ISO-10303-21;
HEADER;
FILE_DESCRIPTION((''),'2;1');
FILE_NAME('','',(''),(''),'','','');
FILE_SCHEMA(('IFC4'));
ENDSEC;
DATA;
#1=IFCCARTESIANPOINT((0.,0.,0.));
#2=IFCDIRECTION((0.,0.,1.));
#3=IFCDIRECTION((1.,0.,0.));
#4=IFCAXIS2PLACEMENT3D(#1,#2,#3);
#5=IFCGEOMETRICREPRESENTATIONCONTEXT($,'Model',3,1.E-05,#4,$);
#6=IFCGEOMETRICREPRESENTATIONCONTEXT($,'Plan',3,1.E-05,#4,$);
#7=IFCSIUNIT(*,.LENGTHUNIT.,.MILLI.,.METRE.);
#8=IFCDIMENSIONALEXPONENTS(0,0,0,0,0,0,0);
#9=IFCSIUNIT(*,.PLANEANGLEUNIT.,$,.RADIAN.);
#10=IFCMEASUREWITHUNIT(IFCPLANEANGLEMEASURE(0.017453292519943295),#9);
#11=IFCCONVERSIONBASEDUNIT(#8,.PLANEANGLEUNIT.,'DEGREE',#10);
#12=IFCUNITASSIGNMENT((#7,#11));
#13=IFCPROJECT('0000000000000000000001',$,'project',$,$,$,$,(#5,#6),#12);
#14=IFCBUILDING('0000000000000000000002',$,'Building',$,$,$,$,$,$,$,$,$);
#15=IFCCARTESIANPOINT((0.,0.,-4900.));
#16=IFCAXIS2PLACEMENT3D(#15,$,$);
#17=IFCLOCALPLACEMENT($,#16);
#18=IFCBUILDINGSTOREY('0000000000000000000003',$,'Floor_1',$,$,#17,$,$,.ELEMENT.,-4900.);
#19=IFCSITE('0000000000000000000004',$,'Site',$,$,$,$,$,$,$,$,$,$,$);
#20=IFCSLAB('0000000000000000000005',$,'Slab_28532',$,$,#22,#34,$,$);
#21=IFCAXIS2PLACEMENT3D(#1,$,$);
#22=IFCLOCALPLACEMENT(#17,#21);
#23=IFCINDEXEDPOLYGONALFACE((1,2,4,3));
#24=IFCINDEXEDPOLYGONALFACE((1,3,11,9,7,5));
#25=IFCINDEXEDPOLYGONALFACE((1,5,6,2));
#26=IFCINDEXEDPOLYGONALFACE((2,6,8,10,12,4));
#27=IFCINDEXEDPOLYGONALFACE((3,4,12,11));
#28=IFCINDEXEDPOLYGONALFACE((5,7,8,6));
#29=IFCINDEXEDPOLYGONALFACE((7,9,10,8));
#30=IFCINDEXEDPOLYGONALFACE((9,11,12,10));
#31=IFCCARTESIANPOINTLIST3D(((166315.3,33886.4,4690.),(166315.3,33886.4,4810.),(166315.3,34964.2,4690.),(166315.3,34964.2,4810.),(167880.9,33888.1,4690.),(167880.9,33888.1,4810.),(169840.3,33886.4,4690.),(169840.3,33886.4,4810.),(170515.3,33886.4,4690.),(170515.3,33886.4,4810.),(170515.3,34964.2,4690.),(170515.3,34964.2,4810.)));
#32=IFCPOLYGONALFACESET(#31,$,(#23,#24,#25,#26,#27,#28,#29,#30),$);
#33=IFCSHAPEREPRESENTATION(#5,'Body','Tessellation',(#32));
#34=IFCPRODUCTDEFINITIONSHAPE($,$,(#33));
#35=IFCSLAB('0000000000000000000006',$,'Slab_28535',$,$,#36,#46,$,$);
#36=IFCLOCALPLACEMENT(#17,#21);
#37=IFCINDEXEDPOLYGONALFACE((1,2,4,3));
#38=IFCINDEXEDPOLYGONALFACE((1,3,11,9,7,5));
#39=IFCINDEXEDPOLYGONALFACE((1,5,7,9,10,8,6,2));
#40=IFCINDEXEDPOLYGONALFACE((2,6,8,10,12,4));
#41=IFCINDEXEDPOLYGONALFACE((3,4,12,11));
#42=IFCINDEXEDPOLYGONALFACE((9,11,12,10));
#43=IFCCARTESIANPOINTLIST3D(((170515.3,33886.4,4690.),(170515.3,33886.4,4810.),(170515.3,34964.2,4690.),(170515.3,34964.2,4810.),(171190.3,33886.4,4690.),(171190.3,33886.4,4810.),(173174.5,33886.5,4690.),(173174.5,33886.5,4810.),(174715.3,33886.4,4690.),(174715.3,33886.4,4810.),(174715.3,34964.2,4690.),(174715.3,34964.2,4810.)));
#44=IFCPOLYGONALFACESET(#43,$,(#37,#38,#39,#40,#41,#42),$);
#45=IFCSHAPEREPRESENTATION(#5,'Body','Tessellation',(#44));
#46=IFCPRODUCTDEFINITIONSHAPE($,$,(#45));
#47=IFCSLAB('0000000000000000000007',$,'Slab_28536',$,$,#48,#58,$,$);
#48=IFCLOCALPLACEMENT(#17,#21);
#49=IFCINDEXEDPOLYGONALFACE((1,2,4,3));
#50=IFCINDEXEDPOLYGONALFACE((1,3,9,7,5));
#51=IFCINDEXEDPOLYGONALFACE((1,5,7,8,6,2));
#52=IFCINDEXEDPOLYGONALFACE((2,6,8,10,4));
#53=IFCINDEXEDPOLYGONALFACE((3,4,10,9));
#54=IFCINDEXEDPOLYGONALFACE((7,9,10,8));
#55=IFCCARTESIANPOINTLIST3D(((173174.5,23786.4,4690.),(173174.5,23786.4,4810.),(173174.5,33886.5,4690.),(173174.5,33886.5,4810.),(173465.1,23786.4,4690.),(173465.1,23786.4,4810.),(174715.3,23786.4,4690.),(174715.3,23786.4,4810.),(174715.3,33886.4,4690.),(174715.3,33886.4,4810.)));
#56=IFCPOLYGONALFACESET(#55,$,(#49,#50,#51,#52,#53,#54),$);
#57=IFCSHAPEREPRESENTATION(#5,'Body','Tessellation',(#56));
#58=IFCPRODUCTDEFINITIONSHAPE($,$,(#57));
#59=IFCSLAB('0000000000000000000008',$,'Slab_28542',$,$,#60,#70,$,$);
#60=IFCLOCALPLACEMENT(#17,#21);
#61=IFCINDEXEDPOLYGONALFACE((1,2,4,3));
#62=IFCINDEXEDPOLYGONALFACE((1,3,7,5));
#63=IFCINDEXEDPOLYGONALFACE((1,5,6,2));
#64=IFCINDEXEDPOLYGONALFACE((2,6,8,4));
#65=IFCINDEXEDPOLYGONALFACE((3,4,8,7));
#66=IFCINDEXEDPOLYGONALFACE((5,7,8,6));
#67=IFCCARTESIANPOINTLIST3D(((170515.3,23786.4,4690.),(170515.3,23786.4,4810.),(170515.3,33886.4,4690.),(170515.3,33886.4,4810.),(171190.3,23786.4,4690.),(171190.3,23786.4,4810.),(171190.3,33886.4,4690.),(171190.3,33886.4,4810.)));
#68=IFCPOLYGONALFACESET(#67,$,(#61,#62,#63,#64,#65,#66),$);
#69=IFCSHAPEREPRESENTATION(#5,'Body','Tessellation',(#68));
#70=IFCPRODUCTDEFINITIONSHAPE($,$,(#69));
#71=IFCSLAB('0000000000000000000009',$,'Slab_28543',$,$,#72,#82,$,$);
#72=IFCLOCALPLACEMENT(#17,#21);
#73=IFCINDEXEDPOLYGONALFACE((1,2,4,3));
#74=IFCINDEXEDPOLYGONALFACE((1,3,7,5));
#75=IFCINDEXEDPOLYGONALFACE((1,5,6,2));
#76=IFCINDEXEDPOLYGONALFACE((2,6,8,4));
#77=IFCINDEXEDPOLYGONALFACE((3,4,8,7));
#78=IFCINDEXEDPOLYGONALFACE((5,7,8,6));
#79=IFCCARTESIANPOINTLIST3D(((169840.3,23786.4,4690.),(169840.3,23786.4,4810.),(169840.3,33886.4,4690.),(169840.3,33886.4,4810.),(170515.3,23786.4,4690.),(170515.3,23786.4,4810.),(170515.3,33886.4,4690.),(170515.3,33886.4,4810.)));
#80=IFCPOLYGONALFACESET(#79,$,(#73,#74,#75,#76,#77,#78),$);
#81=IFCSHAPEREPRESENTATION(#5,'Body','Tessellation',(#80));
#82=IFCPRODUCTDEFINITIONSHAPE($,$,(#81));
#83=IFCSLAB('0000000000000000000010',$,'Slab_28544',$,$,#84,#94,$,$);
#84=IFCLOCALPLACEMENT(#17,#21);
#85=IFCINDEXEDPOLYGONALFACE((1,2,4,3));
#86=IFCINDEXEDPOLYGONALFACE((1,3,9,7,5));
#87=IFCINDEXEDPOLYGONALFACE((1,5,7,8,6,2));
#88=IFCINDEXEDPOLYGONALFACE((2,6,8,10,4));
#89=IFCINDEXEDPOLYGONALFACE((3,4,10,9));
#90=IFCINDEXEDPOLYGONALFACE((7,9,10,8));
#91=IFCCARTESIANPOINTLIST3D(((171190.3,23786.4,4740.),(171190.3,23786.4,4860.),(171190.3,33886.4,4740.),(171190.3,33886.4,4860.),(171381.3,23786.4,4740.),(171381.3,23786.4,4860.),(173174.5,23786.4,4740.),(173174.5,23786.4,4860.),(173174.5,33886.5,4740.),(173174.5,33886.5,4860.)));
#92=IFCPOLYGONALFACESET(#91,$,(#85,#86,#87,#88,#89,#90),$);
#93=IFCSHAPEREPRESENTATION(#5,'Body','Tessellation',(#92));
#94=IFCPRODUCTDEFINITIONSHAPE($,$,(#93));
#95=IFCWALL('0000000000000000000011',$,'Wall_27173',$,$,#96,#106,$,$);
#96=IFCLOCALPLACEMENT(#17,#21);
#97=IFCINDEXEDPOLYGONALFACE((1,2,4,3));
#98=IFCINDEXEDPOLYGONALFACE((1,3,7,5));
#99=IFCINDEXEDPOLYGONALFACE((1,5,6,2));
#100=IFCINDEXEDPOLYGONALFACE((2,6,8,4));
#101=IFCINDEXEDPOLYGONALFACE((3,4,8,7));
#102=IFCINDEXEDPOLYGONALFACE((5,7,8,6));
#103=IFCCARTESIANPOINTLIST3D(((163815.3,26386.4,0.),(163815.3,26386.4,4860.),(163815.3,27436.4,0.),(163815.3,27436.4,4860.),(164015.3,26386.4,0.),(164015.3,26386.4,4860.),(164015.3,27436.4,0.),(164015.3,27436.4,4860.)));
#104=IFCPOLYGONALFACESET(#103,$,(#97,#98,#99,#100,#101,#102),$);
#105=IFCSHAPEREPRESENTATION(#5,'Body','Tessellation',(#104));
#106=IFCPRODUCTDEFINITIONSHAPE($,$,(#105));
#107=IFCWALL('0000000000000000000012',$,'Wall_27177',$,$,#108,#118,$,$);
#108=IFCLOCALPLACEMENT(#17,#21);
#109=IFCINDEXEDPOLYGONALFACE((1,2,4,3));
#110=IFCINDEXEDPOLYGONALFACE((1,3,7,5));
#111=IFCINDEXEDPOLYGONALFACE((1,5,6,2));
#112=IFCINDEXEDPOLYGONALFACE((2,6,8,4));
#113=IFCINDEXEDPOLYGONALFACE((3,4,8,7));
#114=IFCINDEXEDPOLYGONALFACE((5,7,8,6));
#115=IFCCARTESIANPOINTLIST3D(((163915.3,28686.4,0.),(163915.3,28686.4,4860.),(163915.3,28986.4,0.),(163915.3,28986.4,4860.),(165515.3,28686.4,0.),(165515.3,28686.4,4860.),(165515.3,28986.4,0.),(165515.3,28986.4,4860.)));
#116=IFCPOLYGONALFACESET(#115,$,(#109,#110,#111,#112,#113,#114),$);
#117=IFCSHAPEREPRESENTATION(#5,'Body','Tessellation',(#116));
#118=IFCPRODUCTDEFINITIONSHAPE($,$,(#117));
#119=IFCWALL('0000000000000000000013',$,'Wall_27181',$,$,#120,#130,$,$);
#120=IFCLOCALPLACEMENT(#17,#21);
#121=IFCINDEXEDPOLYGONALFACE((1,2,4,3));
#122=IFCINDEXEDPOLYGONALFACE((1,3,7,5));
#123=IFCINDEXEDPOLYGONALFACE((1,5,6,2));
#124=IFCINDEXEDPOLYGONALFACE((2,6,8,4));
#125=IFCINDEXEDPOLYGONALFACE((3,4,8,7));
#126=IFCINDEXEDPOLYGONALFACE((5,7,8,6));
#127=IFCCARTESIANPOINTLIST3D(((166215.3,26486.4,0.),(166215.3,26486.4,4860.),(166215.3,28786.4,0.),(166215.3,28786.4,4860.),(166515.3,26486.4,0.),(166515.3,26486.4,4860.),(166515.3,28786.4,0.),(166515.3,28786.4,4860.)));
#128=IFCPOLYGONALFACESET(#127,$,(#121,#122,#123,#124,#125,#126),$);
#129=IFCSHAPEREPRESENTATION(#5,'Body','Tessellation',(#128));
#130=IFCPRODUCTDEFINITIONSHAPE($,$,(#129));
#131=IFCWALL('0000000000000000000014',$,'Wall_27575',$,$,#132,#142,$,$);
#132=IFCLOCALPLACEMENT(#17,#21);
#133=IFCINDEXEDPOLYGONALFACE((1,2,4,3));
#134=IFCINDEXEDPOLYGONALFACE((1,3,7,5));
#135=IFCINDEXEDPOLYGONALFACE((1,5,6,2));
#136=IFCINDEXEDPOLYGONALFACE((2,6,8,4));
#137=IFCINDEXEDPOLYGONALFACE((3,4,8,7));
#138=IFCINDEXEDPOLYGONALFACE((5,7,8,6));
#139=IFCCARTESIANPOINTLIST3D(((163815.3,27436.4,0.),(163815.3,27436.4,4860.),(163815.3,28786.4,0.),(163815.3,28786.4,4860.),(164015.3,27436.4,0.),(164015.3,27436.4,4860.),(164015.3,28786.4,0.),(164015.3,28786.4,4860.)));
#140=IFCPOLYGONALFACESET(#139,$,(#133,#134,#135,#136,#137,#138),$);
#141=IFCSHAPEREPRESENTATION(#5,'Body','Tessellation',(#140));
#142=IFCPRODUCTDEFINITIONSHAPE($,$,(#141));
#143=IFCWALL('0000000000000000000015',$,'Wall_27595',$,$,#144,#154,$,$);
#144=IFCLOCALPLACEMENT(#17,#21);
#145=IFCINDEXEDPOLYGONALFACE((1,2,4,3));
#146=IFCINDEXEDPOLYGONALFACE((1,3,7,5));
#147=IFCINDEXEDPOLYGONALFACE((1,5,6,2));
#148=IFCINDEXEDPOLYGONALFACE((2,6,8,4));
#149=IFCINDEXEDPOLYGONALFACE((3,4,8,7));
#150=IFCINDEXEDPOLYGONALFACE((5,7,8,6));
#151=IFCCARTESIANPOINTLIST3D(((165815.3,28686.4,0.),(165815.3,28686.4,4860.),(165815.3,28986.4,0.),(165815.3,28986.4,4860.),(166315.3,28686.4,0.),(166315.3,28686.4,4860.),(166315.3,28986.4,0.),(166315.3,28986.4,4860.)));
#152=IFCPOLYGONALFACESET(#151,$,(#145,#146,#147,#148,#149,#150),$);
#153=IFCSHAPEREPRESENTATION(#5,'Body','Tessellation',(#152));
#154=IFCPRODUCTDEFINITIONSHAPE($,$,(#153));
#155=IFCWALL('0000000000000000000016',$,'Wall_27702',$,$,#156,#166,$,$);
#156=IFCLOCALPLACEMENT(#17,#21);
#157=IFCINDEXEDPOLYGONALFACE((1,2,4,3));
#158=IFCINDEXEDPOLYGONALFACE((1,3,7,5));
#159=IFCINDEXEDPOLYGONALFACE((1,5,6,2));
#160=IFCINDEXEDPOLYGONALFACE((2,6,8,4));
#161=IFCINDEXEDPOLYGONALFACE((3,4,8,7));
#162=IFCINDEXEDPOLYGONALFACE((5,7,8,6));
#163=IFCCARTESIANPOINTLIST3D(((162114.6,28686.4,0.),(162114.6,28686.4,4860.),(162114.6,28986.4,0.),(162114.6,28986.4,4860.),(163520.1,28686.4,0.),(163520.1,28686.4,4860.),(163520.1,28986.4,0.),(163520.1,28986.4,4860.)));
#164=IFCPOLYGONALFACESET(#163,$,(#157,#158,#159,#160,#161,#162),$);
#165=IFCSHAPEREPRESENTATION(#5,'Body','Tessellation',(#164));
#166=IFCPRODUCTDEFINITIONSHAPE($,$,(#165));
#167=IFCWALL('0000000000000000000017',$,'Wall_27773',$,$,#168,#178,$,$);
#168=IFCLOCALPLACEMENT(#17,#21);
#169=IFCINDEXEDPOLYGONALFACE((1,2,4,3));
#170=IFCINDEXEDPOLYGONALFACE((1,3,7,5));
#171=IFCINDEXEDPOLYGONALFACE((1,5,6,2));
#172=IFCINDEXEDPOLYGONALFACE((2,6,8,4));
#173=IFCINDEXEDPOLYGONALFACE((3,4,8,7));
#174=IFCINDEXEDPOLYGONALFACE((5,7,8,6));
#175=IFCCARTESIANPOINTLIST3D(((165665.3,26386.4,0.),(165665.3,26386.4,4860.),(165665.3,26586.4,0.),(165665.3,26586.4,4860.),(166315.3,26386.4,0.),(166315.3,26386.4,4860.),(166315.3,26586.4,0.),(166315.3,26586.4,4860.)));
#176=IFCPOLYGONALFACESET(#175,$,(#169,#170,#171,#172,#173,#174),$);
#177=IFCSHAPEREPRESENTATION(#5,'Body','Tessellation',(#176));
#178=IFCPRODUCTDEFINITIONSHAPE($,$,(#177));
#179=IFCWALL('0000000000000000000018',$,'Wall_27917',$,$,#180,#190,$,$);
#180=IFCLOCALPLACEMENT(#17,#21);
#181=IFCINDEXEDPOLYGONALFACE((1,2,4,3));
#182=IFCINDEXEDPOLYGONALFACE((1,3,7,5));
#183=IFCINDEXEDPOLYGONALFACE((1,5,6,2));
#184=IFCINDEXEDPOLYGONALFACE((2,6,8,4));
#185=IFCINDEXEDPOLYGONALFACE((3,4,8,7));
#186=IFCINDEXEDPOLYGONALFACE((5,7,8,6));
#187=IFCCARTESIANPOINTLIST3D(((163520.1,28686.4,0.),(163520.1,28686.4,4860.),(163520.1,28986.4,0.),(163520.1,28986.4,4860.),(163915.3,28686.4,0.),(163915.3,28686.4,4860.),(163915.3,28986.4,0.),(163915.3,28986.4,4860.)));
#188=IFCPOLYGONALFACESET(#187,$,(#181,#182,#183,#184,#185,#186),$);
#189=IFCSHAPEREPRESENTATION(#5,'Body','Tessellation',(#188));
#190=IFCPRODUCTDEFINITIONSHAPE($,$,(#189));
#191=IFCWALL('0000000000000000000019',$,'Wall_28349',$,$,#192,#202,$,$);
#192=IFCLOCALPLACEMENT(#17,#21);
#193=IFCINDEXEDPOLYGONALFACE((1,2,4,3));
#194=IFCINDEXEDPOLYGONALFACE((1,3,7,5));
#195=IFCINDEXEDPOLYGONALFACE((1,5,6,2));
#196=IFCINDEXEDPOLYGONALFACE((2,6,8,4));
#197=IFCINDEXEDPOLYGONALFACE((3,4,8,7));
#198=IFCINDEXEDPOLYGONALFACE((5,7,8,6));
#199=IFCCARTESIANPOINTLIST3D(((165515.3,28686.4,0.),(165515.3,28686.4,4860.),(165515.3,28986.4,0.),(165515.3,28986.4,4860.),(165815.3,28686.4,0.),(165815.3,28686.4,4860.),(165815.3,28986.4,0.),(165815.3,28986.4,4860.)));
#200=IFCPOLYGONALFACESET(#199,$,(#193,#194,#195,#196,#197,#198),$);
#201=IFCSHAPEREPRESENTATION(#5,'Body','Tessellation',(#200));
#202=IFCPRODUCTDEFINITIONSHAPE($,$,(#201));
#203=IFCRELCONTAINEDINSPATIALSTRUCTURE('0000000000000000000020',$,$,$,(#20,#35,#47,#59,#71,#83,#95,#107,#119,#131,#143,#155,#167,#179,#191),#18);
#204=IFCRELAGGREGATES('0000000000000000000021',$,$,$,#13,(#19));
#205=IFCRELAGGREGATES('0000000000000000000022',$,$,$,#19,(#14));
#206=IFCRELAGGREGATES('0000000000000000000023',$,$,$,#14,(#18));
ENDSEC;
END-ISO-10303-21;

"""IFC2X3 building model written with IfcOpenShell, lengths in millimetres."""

from ifc_helpers import new_model, entity, si_unit, converted_unit, frame, origin_with_axes, origin_2d, place, context, project, spatial, polyline, rectangle, outline, extrude, element, save


model = new_model("IFC2X3")

# Units and contexts
model_context = context("Model", 3, precision=1e-05, world=origin_with_axes())
plan_context = context("Plan", 3, precision=1e-05, world=origin_with_axes())
ifc_project = project(units=[si_unit("LENGTHUNIT", "METRE", prefix="MILLI"), converted_unit("PLANEANGLEUNIT", "DEGREE", entity("IfcPlaneAngleMeasure", 0.017453292519943295), si_unit("PLANEANGLEUNIT", "RADIAN"), dimensions=[0, 0, 0, 0, 0, 0, 0])], contexts=[model_context, plan_context])

# Site, building, storey
site = spatial("IfcSite", under=ifc_project, Name="Site")
building = spatial("IfcBuilding", under=site, Name="Building")
storey_placement = place(None, frame((0.0, 0.0, -4900.0)))
storey = spatial("IfcBuildingStorey", under=building, at=storey_placement, Name="Floor_1", CompositionType="ELEMENT", Elevation=-4900.0)

# Slabs
slab_1_placement = place(storey_placement, frame((166315.3, 34964.2, 4690.0), z_axis=(0.0, 0.0, 1.0), x_axis=(0.0, -1077.803, 0.0)))
element("IfcSlab", 1, at=slab_1_placement, inside=storey, Name="Slab_28532", context=model_context, shape_type="SweptSolid", body=[
    extrude(outline(polyline([(0.0, 0.0), (1077.8, 0.0), (1076.0, 1565.5), (1077.8, 3525.0), (1077.8, 4200.0), (0.0, 4200.0)])), origin_with_axes(), (0.0, 0.0, 1.0), 120.0),
])
slab_2_placement = place(storey_placement, frame((170515.3, 34964.2, 4690.0), z_axis=(0.0, 0.0, 1.0), x_axis=(0.0, -1077.803, 0.0)))
element("IfcSlab", 2, at=slab_2_placement, inside=storey, Name="Slab_28535", context=model_context, shape_type="SweptSolid", body=[
    extrude(outline(polyline([(0.0, 0.0), (1077.8, 0.0), (1077.8, 675.0), (1077.6, 2659.2), (1077.8, 4200.0), (0.0, 4200.0)])), origin_with_axes(), (0.0, 0.0, 1.0), 120.0),
])
slab_3_placement = place(storey_placement, frame((173174.5, 33886.5, 4690.0), z_axis=(0.0, 0.0, 1.0), x_axis=(0.0, -10100.179, 0.0)))
element("IfcSlab", 3, at=slab_3_placement, inside=storey, Name="Slab_28536", context=model_context, shape_type="SweptSolid", body=[
    extrude(outline(polyline([(0.0, 0.0), (10100.2, 0.0), (10100.2, 290.6), (10100.2, 1540.8), (0.2, 1540.8)])), origin_with_axes(), (0.0, 0.0, 1.0), 120.0),
])
for number, where, z_axis, x_axis, name in (
    (4, (170515.3, 33886.4, 4690.0), (0.0, 0.0, 1.0), (0.0, -10100.0, 0.0), "Slab_28542"),
    (5, (169840.3, 33886.4, 4690.0), (0.0, 0.0, 1.0), (0.0, -10100.0, 0.0), "Slab_28543"),
):
    element("IfcSlab", number, at=place(storey_placement, frame(where, z_axis=z_axis, x_axis=x_axis)), inside=storey, Name=name, context=model_context, shape_type="SweptSolid", body=[
        extrude(outline(polyline([(0.0, 0.0), (10100.0, 0.0), (10100.0, 675.0), (0.0, 675.0)])), origin_with_axes(), (0.0, 0.0, 1.0), 120.0),
    ])
slab_4_placement = place(storey_placement, frame((171190.3, 33886.4, 4740.0), z_axis=(0.0, 0.0, 1.0), x_axis=(0.0, -10100.0, 0.0)))
element("IfcSlab", 6, at=slab_4_placement, inside=storey, Name="Slab_28544", context=model_context, shape_type="SweptSolid", body=[
    extrude(outline(polyline([(0.0, 0.0), (10100.0, 0.0), (10100.0, 191.0), (10100.0, 1984.2), (-0.2, 1984.2)])), origin_with_axes(), (0.0, 0.0, 1.0), 120.0),
])

# Walls
wall_1_placement = place(storey_placement, frame((163915.3, 26911.4, 0.0), z_axis=(0.0, 0.0, 1.0), x_axis=(0.0, 1050.0, 0.0)))
element("IfcWall", 7, at=wall_1_placement, inside=storey, Name="Wall_27173", context=model_context, shape_type="SweptSolid", body=[
    extrude(rectangle(XDim=1050.0, YDim=200.0, at=origin_2d()), origin_with_axes(), (0.0, 0.0, 1.0), 4860.0),
])
wall_2_placement = place(storey_placement, frame((164715.3, 28836.4, 0.0), z_axis=(0.0, 0.0, 1.0), x_axis=(1600.000484, 0.0, 0.0)))
element("IfcWall", 8, at=wall_2_placement, inside=storey, Name="Wall_27177", context=model_context, shape_type="SweptSolid", body=[
    extrude(rectangle(XDim=1600.0, YDim=300.0, at=origin_2d()), origin_with_axes(), (0.0, 0.0, 1.0), 4860.0),
])
wall_3_placement = place(storey_placement, frame((166365.3, 27636.4, 0.0), z_axis=(0.0, 0.0, 1.0), x_axis=(0.0, 2300.0, 0.0)))
element("IfcWall", 9, at=wall_3_placement, inside=storey, Name="Wall_27181", context=model_context, shape_type="SweptSolid", body=[
    extrude(rectangle(XDim=2300.0, YDim=300.0, at=origin_2d()), origin_with_axes(), (0.0, 0.0, 1.0), 4860.0),
])
wall_4_placement = place(storey_placement, frame((163915.3, 28111.4, 0.0), z_axis=(0.0, 0.0, 1.0), x_axis=(0.0, 1350.0, 0.0)))
element("IfcWall", 10, at=wall_4_placement, inside=storey, Name="Wall_27575", context=model_context, shape_type="SweptSolid", body=[
    extrude(rectangle(XDim=1350.0, YDim=200.0, at=origin_2d()), origin_with_axes(), (0.0, 0.0, 1.0), 4860.0),
])
wall_5_placement = place(storey_placement, frame((166065.3, 28836.4, 0.0), z_axis=(0.0, 0.0, 1.0), x_axis=(500.0, 0.0, 0.0)))
element("IfcWall", 11, at=wall_5_placement, inside=storey, Name="Wall_27595", context=model_context, shape_type="SweptSolid", body=[
    extrude(rectangle(XDim=500.0, YDim=300.0, at=origin_2d()), origin_with_axes(), (0.0, 0.0, 1.0), 4860.0),
])
wall_6_placement = place(storey_placement, frame((162817.4, 28836.4, 0.0), z_axis=(0.0, 0.0, 1.0), x_axis=(1405.412766, 0.0, 0.0)))
element("IfcWall", 12, at=wall_6_placement, inside=storey, Name="Wall_27702", context=model_context, shape_type="SweptSolid", body=[
    extrude(rectangle(XDim=1405.4, YDim=300.0, at=origin_2d()), origin_with_axes(), (0.0, 0.0, 1.0), 4860.0),
])
wall_7_placement = place(storey_placement, frame((165990.3, 26486.4, 0.0), z_axis=(0.0, 0.0, 1.0), x_axis=(650.0, 0.0, 0.0)))
element("IfcWall", 13, at=wall_7_placement, inside=storey, Name="Wall_27773", context=model_context, shape_type="SweptSolid", body=[
    extrude(rectangle(XDim=650.0, YDim=200.0, at=origin_2d()), origin_with_axes(), (0.0, 0.0, 1.0), 4860.0),
])
wall_8_placement = place(storey_placement, frame((163717.7, 28836.4, 0.0), z_axis=(0.0, 0.0, 1.0), x_axis=(395.269086, 0.0, 0.0)))
element("IfcWall", 14, at=wall_8_placement, inside=storey, Name="Wall_27917", context=model_context, shape_type="SweptSolid", body=[
    extrude(rectangle(XDim=395.3, YDim=300.0, at=origin_2d()), origin_with_axes(), (0.0, 0.0, 1.0), 4860.0),
])
wall_9_placement = place(storey_placement, frame((165665.3, 28836.4, 0.0), z_axis=(0.0, 0.0, 1.0), x_axis=(299.999516, 0.0, 0.0)))
element("IfcWall", 15, at=wall_9_placement, inside=storey, Name="Wall_28349", context=model_context, shape_type="SweptSolid", body=[
    extrude(rectangle(XDim=300.0, YDim=300.0, at=origin_2d()), origin_with_axes(), (0.0, 0.0, 1.0), 4860.0),
])

save(model, "model.ifc")
